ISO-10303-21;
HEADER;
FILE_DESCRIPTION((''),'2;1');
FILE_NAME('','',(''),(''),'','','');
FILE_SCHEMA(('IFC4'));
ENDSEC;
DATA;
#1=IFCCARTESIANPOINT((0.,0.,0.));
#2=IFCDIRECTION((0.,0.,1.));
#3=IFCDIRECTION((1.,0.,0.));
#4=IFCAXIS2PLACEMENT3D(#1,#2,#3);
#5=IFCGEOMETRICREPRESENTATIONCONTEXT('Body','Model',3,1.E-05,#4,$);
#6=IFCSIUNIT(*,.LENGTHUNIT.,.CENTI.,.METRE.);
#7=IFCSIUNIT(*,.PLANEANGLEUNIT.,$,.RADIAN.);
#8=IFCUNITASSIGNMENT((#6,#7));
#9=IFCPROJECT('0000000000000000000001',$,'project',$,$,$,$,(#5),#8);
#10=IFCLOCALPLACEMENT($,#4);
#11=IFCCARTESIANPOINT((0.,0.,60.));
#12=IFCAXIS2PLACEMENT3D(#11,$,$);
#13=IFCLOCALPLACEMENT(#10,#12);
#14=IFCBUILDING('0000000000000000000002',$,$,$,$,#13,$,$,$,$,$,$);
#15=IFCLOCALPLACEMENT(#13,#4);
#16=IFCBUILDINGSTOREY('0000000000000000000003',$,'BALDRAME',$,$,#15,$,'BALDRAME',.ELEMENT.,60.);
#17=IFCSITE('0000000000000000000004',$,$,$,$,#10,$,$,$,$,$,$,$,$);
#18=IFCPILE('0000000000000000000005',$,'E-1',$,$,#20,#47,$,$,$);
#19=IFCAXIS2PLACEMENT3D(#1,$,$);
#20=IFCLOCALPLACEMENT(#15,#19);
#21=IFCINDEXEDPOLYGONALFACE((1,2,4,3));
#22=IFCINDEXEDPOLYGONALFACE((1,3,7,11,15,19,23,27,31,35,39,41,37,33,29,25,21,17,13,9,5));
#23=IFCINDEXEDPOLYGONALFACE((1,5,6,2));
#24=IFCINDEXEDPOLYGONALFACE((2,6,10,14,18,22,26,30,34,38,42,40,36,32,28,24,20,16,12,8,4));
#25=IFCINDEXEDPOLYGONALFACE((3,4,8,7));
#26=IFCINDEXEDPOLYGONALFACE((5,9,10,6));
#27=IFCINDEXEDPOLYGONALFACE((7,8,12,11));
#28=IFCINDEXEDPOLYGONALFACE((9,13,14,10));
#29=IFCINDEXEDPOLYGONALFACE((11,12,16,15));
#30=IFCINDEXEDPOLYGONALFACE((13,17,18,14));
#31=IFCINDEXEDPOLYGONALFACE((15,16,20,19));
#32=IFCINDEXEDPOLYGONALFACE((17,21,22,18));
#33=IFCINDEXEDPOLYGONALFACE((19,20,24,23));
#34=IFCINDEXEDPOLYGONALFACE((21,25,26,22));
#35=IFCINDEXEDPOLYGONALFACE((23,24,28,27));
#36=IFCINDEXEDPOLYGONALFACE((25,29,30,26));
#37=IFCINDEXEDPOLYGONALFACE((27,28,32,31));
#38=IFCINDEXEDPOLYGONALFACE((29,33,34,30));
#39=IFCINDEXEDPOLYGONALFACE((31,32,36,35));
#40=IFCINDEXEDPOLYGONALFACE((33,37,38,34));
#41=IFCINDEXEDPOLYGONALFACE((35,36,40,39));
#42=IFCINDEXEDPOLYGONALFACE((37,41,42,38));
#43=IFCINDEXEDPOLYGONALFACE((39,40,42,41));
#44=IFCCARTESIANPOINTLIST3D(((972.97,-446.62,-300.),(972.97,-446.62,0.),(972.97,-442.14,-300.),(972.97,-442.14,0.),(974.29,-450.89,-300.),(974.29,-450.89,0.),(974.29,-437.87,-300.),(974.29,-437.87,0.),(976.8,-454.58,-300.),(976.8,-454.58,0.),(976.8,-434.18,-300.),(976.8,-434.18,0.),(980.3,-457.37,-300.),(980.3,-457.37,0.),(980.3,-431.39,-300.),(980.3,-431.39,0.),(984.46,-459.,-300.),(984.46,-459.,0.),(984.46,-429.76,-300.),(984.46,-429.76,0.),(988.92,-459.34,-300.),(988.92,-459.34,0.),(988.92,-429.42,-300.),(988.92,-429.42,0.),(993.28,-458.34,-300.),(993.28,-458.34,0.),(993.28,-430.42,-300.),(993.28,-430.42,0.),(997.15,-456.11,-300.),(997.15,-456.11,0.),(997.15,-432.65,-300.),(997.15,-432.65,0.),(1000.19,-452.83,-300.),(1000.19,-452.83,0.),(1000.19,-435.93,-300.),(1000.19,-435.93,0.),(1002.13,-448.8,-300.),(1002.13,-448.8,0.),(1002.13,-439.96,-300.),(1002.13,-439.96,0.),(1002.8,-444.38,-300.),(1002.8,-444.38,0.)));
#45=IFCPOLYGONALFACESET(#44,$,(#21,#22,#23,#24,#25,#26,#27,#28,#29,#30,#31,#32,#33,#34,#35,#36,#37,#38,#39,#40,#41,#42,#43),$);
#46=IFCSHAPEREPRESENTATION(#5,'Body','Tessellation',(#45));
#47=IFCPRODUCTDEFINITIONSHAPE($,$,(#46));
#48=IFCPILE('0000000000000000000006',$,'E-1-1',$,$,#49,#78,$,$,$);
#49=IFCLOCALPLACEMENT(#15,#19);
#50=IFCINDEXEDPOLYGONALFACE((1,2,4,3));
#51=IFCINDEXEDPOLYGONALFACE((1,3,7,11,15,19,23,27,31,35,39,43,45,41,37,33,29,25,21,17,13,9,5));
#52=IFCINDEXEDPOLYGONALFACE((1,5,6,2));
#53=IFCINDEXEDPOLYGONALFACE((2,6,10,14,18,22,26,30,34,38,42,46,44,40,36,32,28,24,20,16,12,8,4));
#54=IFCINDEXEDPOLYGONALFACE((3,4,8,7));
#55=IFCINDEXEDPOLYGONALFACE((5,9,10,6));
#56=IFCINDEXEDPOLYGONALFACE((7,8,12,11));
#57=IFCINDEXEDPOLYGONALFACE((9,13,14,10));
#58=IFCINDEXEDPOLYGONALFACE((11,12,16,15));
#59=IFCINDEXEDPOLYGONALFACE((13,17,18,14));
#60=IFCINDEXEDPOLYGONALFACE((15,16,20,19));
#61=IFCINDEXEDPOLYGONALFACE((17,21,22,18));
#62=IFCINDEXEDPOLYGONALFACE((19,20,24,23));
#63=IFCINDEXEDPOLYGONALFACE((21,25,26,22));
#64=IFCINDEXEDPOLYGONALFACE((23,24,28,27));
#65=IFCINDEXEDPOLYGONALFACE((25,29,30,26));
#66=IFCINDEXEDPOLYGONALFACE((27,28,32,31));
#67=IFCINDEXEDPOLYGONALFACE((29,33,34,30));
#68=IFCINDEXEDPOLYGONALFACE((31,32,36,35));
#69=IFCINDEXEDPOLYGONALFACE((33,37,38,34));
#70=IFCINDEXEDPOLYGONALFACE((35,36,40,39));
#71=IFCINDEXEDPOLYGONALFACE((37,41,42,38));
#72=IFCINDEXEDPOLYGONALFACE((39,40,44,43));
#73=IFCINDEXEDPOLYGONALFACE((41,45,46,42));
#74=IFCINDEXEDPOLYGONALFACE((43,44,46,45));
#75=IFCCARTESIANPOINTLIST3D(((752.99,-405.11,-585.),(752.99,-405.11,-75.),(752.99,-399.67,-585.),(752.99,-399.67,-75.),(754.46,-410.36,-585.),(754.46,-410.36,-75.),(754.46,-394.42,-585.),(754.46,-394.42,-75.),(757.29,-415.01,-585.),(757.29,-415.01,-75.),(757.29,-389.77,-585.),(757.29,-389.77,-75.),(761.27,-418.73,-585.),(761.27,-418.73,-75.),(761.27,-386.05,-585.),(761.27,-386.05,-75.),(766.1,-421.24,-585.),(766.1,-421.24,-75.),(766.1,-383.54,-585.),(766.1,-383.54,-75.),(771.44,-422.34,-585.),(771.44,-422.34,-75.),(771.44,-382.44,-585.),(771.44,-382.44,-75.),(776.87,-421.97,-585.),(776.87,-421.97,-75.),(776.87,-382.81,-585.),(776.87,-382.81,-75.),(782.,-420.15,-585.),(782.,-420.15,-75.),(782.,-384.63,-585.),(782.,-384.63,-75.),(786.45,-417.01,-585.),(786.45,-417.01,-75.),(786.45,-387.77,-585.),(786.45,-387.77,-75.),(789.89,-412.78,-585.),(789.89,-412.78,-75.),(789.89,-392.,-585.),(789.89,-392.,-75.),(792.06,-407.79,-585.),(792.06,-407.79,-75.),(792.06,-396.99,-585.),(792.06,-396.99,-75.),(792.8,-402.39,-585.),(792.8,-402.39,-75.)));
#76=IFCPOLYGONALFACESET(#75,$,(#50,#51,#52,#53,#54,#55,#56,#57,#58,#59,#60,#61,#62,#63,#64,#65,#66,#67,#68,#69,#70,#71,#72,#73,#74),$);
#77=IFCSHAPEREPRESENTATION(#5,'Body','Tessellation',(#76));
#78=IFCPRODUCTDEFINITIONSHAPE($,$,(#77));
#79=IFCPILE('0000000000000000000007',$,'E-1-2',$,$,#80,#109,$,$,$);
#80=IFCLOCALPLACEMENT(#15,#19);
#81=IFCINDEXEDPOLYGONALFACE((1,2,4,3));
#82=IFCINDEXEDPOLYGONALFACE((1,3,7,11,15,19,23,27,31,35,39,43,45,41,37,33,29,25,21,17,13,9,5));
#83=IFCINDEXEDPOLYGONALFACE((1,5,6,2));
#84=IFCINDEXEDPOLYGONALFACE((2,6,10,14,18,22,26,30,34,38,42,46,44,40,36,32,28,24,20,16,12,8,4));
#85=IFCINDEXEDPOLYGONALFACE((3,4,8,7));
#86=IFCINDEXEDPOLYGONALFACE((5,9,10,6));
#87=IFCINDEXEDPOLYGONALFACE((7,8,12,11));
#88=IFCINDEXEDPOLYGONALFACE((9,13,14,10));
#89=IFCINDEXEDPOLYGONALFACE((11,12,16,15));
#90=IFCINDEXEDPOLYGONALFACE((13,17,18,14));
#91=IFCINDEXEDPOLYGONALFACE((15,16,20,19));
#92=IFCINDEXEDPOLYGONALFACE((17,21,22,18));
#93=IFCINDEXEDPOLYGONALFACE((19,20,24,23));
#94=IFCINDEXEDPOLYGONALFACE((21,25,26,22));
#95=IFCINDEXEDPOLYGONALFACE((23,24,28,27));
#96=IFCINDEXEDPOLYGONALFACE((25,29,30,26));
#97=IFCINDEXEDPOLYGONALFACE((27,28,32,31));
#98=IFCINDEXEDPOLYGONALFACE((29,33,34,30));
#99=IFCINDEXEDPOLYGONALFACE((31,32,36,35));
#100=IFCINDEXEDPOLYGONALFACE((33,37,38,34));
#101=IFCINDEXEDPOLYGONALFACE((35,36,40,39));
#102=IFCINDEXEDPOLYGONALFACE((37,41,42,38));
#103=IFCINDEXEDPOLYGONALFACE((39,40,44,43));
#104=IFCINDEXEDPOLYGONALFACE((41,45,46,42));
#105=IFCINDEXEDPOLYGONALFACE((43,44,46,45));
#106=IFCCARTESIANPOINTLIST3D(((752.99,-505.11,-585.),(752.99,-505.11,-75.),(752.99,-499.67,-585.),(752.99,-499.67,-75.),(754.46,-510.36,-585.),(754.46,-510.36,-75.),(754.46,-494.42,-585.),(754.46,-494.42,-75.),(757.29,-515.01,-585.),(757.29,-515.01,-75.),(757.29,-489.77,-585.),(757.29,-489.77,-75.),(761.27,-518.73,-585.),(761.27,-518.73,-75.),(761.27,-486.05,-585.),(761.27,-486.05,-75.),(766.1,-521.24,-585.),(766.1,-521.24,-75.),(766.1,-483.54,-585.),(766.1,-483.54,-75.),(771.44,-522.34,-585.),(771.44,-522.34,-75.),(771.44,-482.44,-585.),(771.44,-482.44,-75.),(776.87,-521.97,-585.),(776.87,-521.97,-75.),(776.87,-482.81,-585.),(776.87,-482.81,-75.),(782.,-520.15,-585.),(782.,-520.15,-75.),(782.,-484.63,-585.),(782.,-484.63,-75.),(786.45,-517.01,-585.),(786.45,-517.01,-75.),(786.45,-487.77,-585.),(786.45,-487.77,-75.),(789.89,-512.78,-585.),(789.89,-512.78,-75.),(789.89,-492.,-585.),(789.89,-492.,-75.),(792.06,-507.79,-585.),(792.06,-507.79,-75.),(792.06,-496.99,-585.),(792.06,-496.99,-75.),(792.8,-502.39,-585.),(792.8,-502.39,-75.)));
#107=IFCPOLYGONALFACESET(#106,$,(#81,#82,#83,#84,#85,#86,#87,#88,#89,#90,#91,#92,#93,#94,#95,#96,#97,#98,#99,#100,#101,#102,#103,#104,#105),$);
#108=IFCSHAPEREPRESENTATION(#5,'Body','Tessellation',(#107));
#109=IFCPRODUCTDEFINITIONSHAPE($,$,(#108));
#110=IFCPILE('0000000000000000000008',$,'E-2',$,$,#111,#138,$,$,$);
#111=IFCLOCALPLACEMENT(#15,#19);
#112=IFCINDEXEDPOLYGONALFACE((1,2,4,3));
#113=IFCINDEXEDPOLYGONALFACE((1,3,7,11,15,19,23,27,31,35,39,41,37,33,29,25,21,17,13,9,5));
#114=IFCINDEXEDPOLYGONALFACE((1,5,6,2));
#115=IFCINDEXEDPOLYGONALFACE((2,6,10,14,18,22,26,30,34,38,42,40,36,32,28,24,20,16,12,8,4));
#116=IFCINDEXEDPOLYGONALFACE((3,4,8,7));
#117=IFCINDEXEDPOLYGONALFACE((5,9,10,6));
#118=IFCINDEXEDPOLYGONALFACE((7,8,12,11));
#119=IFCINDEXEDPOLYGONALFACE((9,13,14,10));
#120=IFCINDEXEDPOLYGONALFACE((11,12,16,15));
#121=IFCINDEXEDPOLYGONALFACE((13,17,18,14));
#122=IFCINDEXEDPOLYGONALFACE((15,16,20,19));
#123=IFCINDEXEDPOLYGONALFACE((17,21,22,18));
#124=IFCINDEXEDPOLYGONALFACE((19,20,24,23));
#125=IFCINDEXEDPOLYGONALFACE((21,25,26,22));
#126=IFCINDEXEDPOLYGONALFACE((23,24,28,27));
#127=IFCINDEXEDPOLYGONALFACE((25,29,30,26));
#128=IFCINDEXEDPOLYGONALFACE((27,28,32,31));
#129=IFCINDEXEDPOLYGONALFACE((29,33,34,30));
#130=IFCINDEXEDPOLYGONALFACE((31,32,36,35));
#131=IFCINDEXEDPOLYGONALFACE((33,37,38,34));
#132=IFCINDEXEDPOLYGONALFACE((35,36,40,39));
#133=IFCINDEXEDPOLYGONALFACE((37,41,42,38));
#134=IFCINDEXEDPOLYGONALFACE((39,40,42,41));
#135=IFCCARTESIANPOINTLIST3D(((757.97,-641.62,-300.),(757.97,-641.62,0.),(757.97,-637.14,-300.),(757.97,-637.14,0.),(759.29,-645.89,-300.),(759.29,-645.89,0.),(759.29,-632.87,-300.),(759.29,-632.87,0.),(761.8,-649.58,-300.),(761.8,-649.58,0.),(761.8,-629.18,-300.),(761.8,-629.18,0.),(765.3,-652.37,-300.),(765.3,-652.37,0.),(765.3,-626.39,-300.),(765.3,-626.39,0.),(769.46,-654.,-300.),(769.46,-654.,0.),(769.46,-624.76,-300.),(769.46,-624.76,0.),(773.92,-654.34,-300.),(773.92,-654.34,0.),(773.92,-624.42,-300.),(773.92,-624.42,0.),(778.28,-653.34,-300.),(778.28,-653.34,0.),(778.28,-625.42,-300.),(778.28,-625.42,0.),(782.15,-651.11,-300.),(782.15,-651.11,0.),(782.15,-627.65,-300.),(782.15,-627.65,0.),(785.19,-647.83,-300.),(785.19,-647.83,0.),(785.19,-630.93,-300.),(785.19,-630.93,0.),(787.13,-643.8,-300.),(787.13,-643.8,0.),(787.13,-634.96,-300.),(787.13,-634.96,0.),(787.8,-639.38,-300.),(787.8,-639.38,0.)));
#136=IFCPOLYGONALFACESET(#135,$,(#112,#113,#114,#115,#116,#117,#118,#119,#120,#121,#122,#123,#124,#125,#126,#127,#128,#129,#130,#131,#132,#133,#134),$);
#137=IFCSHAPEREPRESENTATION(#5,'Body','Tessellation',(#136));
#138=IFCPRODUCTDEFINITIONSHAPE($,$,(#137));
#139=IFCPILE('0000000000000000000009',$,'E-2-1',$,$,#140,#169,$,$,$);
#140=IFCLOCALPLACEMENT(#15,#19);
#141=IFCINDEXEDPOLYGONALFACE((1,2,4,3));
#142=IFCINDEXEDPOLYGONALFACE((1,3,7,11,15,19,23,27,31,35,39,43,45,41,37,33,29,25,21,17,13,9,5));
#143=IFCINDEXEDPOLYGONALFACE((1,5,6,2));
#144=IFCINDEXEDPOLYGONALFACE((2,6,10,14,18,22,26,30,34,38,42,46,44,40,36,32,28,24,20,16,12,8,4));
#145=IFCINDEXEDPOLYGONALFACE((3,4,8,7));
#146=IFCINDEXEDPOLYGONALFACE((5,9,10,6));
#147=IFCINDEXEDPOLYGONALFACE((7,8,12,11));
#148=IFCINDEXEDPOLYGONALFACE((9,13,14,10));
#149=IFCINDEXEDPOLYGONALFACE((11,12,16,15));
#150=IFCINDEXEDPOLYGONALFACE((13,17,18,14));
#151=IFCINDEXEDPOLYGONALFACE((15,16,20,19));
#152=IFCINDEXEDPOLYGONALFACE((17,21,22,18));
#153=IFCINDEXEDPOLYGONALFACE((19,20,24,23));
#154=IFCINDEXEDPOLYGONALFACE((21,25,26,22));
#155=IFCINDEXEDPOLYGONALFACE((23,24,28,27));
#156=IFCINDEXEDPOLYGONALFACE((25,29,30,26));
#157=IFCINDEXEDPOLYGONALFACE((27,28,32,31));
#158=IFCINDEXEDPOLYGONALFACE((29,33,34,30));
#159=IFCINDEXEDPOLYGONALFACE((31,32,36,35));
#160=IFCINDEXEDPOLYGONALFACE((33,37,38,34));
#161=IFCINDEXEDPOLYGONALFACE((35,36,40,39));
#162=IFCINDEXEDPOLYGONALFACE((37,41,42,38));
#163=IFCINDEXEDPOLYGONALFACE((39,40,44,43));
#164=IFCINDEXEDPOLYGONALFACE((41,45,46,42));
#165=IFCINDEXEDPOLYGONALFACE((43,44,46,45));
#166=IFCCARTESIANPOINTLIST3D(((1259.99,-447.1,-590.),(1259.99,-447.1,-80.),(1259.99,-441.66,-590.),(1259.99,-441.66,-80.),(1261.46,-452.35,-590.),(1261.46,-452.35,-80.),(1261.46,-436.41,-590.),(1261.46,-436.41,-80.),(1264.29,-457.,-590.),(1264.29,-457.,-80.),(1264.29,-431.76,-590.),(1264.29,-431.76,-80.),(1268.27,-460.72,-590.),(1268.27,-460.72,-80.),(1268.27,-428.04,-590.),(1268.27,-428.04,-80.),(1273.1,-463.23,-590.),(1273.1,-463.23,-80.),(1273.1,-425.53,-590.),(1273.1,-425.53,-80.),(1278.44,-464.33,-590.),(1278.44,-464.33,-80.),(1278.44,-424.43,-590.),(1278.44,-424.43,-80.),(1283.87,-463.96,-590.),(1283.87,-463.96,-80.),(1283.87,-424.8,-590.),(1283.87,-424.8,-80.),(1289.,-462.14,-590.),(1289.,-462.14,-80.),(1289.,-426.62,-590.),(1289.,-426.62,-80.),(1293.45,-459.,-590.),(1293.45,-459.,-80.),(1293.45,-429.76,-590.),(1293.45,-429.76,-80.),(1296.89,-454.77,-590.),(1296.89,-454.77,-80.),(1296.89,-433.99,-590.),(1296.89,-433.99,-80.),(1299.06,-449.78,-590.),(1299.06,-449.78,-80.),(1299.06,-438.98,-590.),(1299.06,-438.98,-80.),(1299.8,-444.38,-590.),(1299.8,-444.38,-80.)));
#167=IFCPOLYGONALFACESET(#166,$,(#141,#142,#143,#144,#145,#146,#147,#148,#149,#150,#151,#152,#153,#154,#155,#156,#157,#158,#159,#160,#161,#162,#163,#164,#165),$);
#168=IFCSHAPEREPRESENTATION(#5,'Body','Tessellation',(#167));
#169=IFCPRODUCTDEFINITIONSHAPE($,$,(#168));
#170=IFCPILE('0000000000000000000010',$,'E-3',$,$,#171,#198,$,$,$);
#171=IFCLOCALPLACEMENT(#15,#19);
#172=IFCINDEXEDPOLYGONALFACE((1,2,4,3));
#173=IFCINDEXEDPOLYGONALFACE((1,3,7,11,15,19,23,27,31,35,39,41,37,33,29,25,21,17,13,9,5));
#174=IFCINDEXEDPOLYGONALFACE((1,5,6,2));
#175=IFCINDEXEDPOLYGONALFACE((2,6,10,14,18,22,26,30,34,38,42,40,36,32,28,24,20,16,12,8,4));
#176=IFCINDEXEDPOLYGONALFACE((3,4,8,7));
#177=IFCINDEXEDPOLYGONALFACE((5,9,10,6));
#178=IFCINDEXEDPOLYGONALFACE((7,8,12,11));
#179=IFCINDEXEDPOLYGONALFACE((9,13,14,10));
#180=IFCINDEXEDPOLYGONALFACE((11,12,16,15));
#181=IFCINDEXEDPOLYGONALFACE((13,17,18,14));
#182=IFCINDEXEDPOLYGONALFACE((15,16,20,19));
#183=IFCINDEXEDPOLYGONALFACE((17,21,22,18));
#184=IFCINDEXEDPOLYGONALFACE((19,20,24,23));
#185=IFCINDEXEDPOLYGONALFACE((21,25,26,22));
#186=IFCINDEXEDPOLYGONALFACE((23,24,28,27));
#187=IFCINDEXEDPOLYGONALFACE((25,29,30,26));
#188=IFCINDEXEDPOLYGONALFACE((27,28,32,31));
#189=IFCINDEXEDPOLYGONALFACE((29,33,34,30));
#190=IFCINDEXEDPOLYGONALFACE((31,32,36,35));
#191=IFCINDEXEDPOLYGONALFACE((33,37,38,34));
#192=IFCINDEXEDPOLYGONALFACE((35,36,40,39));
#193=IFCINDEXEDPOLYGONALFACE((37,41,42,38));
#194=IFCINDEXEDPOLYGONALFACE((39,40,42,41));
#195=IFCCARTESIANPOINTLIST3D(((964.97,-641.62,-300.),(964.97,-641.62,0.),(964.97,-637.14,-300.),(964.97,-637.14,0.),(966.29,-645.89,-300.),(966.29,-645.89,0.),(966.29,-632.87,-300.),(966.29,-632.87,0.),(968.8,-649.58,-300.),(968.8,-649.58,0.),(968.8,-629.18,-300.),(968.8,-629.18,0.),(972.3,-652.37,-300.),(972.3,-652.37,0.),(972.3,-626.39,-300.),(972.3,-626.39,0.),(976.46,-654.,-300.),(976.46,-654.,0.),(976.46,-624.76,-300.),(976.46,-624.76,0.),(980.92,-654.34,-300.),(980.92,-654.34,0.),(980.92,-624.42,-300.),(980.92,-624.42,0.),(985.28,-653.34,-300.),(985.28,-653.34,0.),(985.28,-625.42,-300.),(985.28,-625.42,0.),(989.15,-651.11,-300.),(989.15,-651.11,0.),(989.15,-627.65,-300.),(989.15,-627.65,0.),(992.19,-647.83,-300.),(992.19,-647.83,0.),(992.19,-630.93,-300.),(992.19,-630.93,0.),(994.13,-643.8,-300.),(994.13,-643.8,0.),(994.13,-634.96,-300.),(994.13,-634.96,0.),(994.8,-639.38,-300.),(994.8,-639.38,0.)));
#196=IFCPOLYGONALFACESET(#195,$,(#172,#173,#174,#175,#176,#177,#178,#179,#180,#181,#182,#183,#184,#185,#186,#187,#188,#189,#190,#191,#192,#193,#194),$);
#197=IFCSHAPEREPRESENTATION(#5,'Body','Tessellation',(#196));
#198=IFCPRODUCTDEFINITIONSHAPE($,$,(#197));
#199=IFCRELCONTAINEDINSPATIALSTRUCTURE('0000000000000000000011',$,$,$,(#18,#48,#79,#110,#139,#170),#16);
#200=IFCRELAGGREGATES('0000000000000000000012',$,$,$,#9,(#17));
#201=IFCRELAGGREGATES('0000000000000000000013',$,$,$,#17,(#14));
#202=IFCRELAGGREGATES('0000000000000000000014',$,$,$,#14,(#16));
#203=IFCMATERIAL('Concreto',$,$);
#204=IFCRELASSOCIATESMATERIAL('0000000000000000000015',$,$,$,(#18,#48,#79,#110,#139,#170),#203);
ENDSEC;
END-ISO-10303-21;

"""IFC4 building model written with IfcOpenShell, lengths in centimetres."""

from ifc_helpers import new_model, si_unit, frame, origin_with_axes, origin_2d_with_axis, place, context, project, spatial, circle, extrude, material, element, save


model = new_model("IFC4")

# Units and contexts
model_context = context("Model", 3, precision=1e-05, world=origin_with_axes(), identifier="Body")
ifc_project = project(units=[si_unit("LENGTHUNIT", "METRE", prefix="CENTI"), si_unit("PLANEANGLEUNIT", "RADIAN")], contexts=[model_context])

# Site, building, storey
site_placement = place(None, origin_with_axes())
site = spatial("IfcSite", under=ifc_project, at=site_placement)
building_placement = place(site_placement, frame((0.0, 0.0, 60.0)))
building = spatial("IfcBuilding", under=site, at=building_placement)
storey_placement = place(building_placement, origin_with_axes())
storey = spatial("IfcBuildingStorey", under=building, at=storey_placement, Name="BALDRAME", LongName="BALDRAME", CompositionType="ELEMENT", Elevation=60.0)

# Piles
ifc_material = material(Name="Concreto")
pile_1_placement = place(storey_placement, frame((987.8, -444.38, 0.0), z_axis=(0.0, 0.0, 1.0), x_axis=(1.0, 0.0, 0.0)))
element("IfcPile", 1, at=pile_1_placement, inside=storey, material=ifc_material, Name="E-1", context=model_context, shape_type="SolidModel", body=[
    extrude(circle(Radius=15.0, at=origin_2d_with_axis()), frame((0.0, 0.0, -300.0), z_axis=(0.0, 0.0, 1.0), x_axis=(1.0, 0.0, 0.0)), (0.0, 0.0, 1.0), 300.0),
])
for number, where, z_axis, x_axis, name in (
    (2, (772.8, -402.39, -75.0), (0.0, 0.0, 1.0), (1.0, 0.0, 0.0), "E-1-1"),
    (3, (772.8, -502.39, -75.0), (0.0, 0.0, 1.0), (1.0, 0.0, 0.0), "E-1-2"),
):
    element("IfcPile", number, at=place(storey_placement, frame(where, z_axis=z_axis, x_axis=x_axis)), inside=storey, material=ifc_material, Name=name, context=model_context, shape_type="SweptSolid", body=[
        extrude(circle(Radius=20.0, at=origin_2d_with_axis()), frame((0.0, 0.0, -510.0), z_axis=(0.0, 0.0, 1.0), x_axis=(1.0, 0.0, 0.0)), (0.0, 0.0, 1.0), 510.0),
    ])
pile_2_placement = place(storey_placement, frame((772.8, -639.38, 0.0), z_axis=(0.0, 0.0, 1.0), x_axis=(1.0, 0.0, 0.0)))
element("IfcPile", 4, at=pile_2_placement, inside=storey, material=ifc_material, Name="E-2", context=model_context, shape_type="SolidModel", body=[
    extrude(circle(Radius=15.0, at=origin_2d_with_axis()), frame((0.0, 0.0, -300.0), z_axis=(0.0, 0.0, 1.0), x_axis=(1.0, 0.0, 0.0)), (0.0, 0.0, 1.0), 300.0),
])
pile_3_placement = place(storey_placement, frame((1279.8, -444.38, -80.0), z_axis=(0.0, 0.0, 1.0), x_axis=(1.0, 0.0, 0.0)))
element("IfcPile", 5, at=pile_3_placement, inside=storey, material=ifc_material, Name="E-2-1", context=model_context, shape_type="SweptSolid", body=[
    extrude(circle(Radius=20.0, at=origin_2d_with_axis()), frame((0.0, 0.0, -510.0), z_axis=(0.0, 0.0, 1.0), x_axis=(1.0, 0.0, 0.0)), (0.0, 0.0, 1.0), 510.0),
])
pile_4_placement = place(storey_placement, frame((979.8, -639.38, 0.0), z_axis=(0.0, 0.0, 1.0), x_axis=(1.0, 0.0, 0.0)))
element("IfcPile", 6, at=pile_4_placement, inside=storey, material=ifc_material, Name="E-3", context=model_context, shape_type="SolidModel", body=[
    extrude(circle(Radius=15.0, at=origin_2d_with_axis()), frame((0.0, 0.0, -300.0), z_axis=(0.0, 0.0, 1.0), x_axis=(1.0, 0.0, 0.0)), (0.0, 0.0, 1.0), 300.0),
])

save(model, "model.ifc")
